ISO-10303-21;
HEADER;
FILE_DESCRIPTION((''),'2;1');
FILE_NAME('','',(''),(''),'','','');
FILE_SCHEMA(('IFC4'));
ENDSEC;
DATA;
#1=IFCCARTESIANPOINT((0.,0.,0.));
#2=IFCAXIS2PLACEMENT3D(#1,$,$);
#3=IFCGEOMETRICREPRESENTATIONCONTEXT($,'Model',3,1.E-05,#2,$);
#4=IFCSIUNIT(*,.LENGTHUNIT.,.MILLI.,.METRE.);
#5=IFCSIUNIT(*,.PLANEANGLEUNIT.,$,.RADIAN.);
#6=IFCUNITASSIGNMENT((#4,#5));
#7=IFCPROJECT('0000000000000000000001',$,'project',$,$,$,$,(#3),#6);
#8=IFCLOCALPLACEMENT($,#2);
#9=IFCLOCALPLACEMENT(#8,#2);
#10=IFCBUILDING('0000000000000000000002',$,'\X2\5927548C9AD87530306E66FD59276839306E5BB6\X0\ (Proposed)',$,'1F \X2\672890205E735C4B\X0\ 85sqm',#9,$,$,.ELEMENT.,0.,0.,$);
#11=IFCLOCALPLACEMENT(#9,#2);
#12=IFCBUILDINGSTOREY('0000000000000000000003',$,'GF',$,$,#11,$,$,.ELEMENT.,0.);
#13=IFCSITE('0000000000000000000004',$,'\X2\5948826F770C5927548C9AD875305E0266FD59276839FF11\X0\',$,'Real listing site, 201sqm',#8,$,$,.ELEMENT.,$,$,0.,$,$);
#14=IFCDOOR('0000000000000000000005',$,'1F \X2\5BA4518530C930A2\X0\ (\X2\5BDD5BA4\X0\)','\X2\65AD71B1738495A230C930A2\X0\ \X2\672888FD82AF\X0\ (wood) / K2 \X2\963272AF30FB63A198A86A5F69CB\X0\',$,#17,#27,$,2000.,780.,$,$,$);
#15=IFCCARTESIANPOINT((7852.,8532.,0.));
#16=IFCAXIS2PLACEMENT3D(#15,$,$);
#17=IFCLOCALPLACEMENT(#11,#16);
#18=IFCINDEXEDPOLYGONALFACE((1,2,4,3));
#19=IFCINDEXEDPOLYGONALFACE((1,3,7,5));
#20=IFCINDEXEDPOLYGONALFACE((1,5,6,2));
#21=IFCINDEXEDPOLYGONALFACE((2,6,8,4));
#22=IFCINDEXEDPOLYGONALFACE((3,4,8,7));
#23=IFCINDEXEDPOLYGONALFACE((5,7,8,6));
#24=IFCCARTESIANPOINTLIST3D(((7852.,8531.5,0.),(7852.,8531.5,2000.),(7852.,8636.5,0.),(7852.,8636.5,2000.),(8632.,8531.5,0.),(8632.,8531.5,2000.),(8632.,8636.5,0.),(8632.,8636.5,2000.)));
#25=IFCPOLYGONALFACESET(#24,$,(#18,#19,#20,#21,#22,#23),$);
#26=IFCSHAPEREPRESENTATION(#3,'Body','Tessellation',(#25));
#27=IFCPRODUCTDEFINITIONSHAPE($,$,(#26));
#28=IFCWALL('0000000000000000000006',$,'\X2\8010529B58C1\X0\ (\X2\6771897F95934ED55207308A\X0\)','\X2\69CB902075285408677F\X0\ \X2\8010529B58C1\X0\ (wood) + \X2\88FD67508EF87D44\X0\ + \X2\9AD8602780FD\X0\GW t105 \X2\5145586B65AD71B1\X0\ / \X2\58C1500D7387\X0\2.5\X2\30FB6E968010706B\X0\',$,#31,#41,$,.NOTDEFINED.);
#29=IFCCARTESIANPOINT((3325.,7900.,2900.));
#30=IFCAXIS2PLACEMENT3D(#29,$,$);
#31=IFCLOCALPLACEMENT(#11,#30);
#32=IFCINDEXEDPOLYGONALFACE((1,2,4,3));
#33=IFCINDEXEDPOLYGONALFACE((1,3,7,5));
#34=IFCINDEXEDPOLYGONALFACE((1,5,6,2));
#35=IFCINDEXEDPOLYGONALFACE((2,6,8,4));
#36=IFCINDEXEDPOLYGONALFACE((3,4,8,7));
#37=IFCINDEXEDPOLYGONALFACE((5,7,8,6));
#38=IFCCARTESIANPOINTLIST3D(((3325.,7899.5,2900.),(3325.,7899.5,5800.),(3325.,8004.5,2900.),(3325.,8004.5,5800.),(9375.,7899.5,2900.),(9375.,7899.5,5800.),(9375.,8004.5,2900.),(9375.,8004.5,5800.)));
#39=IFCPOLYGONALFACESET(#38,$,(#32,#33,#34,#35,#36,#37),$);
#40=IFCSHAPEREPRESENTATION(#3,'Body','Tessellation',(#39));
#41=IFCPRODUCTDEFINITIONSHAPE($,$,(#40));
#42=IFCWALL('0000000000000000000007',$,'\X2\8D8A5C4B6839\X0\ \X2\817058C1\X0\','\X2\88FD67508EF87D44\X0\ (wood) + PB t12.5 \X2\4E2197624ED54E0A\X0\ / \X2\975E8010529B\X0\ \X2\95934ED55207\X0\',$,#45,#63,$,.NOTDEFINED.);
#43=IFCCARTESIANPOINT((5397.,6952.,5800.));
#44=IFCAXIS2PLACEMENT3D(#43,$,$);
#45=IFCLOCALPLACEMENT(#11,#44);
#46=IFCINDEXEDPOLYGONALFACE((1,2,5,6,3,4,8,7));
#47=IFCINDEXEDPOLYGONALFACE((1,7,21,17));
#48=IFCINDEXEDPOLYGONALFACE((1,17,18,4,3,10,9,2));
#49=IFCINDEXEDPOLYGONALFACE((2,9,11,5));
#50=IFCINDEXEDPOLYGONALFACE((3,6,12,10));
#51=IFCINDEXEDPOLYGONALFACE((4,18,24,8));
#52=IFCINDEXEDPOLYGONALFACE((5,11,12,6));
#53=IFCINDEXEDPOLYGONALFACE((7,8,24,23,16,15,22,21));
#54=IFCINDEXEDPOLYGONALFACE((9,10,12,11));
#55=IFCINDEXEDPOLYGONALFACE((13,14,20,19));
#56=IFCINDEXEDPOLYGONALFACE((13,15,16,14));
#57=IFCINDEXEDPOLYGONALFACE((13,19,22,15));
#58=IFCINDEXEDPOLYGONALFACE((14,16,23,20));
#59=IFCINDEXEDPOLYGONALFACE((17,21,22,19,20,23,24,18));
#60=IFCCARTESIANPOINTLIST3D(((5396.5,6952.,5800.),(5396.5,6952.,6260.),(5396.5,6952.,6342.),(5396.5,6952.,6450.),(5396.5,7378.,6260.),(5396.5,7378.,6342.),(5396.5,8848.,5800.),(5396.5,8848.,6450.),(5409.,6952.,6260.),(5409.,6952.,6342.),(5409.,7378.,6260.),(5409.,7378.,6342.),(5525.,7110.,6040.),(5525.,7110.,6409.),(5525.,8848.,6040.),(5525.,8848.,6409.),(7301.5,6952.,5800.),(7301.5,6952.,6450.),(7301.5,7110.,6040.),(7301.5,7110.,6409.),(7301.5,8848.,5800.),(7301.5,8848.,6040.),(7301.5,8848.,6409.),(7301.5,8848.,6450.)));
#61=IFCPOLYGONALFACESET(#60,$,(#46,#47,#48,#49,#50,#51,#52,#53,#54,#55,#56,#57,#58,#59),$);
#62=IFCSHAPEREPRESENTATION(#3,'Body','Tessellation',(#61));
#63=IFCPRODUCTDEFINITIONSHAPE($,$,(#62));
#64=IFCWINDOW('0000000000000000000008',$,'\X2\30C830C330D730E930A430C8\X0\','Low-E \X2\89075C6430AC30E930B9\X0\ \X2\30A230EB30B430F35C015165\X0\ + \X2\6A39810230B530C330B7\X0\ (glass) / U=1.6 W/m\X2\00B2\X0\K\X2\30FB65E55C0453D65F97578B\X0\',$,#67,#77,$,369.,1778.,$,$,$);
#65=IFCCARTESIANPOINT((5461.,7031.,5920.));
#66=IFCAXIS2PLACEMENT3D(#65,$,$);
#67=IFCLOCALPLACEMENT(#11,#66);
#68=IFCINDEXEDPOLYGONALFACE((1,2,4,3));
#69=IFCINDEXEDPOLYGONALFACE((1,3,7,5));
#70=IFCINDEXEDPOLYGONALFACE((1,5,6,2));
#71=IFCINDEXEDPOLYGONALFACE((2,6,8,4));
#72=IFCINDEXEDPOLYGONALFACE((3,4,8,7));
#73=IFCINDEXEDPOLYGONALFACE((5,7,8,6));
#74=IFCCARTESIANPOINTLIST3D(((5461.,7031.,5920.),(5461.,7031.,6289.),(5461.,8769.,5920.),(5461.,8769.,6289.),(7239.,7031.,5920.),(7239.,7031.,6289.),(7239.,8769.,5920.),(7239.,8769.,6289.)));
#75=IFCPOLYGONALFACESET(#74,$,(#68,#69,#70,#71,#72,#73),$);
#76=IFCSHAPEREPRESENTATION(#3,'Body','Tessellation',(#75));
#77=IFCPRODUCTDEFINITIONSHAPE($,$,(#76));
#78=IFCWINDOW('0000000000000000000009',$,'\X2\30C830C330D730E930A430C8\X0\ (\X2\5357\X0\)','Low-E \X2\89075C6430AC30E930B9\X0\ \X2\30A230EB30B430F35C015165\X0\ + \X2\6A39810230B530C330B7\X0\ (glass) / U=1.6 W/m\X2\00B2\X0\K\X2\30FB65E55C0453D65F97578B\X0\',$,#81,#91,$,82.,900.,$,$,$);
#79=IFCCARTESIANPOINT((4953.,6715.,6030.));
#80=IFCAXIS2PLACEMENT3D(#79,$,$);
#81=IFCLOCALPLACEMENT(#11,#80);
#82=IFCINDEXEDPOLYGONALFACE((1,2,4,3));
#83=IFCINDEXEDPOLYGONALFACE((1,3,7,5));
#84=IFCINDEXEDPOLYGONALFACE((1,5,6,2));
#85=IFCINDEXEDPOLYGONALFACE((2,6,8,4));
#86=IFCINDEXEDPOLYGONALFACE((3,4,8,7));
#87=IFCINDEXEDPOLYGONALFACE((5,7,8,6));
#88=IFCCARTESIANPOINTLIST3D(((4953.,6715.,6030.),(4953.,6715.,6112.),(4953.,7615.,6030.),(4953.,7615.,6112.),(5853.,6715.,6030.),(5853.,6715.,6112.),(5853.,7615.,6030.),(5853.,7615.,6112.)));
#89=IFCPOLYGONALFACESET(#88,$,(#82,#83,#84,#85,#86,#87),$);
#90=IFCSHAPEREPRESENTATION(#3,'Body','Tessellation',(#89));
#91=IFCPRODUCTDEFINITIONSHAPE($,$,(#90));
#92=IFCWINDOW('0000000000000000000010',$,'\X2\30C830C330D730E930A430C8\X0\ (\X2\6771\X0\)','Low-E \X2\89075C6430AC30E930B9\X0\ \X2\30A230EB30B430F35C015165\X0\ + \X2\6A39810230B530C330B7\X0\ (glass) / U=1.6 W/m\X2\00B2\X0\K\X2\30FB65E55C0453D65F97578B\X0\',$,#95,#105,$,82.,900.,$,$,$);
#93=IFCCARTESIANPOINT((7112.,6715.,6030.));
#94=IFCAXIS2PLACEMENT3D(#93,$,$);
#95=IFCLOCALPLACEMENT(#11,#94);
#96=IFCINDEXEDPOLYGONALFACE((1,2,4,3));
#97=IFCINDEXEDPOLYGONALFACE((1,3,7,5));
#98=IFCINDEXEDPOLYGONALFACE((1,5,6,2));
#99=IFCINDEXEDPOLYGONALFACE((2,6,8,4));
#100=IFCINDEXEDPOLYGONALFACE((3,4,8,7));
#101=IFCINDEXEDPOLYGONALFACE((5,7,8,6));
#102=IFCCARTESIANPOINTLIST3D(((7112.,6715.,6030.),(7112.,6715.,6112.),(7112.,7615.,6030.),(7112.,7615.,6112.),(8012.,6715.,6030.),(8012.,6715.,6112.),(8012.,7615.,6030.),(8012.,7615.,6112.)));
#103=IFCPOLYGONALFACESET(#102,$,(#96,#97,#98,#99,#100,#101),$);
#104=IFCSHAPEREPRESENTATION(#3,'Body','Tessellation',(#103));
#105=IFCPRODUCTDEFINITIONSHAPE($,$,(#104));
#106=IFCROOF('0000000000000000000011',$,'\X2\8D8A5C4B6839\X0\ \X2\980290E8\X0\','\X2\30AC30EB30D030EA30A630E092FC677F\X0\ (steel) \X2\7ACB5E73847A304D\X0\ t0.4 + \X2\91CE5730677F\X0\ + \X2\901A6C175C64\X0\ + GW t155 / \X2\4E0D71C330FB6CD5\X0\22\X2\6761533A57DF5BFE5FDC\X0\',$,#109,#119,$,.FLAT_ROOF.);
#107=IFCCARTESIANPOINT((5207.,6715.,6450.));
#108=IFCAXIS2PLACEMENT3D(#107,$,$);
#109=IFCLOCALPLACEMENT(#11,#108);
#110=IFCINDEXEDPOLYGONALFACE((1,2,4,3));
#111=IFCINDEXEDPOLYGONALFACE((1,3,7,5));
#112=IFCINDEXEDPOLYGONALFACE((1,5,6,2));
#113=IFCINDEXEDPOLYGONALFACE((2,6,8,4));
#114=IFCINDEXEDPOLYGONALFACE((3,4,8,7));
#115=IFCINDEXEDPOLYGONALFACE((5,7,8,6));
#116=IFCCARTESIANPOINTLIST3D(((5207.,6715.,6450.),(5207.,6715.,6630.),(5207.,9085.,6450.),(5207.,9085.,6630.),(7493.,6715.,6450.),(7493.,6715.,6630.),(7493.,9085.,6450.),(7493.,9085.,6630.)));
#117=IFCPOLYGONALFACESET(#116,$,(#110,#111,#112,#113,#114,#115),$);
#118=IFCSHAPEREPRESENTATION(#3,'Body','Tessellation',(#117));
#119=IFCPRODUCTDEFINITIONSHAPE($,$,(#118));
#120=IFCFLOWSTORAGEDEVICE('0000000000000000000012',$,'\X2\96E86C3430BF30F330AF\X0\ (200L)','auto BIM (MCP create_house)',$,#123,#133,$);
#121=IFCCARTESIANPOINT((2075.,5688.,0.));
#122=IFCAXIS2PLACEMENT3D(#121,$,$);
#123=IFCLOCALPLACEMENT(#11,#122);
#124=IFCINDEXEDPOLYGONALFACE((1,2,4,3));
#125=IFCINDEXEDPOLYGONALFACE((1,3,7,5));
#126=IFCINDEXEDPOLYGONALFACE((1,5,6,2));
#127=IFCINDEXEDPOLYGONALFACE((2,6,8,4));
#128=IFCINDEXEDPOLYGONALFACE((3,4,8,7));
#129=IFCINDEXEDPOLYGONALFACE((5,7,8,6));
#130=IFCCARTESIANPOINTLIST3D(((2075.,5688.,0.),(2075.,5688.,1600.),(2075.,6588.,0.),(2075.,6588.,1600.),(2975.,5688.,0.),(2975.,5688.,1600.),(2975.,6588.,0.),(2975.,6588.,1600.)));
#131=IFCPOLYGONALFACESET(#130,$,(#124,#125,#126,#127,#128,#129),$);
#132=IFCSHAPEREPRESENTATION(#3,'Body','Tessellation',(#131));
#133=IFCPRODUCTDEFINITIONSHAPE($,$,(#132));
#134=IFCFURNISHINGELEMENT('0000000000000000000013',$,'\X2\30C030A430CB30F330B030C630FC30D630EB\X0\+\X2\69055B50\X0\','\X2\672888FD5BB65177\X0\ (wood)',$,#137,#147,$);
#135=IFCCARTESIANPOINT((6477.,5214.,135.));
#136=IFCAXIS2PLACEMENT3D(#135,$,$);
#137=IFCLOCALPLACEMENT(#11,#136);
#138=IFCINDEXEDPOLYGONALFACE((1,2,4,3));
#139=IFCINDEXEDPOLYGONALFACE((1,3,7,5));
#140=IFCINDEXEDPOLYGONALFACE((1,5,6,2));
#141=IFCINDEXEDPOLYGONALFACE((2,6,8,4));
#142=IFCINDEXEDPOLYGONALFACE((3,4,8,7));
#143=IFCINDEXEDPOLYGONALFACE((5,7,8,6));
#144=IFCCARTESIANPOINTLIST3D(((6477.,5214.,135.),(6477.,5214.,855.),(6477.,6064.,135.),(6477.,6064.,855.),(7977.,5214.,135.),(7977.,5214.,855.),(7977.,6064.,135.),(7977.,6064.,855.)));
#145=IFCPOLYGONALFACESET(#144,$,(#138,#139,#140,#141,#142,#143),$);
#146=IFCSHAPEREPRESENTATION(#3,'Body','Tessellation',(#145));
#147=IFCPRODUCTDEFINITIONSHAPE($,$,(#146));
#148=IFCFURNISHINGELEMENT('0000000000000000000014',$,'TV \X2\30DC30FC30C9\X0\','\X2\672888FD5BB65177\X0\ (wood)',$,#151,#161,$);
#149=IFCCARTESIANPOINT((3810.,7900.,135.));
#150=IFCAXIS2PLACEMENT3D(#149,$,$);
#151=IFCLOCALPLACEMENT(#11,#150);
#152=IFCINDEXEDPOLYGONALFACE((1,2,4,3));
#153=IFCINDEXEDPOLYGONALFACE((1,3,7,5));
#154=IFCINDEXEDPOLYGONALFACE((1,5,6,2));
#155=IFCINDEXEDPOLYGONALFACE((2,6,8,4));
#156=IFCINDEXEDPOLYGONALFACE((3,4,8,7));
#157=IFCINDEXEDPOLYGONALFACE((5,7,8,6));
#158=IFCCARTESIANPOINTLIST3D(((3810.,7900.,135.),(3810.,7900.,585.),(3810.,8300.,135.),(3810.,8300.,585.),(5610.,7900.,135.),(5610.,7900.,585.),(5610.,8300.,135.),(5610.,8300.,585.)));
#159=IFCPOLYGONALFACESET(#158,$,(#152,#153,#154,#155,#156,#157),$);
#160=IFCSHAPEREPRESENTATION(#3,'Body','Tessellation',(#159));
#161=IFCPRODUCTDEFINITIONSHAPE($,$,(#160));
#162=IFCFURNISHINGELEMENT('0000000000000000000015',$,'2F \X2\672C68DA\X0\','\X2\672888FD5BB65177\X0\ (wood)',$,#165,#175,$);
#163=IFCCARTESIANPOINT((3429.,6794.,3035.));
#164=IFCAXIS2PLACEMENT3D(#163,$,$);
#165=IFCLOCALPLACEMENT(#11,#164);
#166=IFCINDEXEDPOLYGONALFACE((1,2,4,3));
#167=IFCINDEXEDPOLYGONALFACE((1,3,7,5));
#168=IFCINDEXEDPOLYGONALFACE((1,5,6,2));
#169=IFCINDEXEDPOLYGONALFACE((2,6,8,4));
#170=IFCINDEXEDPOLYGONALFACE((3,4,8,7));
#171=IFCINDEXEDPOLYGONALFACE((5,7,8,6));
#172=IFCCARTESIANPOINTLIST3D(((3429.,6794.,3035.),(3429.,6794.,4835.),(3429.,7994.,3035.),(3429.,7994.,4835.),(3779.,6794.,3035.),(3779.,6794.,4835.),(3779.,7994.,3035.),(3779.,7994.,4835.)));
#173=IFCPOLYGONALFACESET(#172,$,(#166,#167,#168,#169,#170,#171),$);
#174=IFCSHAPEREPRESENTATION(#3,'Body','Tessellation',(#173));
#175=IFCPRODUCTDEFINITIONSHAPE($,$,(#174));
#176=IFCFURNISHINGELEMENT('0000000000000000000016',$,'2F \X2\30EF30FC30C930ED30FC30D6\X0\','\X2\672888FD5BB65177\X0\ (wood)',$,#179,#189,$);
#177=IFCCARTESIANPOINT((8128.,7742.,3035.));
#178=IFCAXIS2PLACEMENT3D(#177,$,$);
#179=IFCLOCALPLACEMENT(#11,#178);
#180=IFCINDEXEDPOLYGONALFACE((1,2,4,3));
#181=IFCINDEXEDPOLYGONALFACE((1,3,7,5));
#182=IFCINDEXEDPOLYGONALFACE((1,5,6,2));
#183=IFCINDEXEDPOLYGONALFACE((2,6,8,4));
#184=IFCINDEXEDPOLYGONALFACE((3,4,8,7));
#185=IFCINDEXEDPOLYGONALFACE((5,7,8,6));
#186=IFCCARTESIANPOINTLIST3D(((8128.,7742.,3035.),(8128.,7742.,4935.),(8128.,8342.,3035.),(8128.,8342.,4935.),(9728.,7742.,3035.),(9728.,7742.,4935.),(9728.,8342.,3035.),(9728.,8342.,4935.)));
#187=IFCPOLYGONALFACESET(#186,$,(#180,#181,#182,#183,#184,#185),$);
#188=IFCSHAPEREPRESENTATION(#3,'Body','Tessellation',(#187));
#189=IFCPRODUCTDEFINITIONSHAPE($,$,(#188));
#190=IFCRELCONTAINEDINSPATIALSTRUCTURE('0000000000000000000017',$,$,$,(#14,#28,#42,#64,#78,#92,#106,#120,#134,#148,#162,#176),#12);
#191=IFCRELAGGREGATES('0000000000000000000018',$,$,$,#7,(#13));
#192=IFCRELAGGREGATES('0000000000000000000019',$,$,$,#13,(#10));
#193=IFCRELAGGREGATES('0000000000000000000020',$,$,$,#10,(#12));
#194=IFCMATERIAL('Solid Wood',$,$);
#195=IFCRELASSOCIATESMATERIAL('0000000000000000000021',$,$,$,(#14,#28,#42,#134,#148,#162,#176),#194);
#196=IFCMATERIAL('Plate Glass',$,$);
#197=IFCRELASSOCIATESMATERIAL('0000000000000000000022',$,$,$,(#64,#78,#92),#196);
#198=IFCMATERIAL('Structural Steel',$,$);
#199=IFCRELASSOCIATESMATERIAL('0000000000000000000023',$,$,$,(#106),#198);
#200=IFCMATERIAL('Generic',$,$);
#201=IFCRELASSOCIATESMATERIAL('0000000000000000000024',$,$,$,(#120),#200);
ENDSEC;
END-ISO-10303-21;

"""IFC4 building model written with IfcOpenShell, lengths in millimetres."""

from ifc_helpers import new_model, si_unit, frame, frame_2d, origin, place, context, project, spatial, rectangle, extrude, material, element, fill, save


model = new_model("IFC4")

# Units and contexts
model_context = context("Model", 3, precision=1e-05, world=origin())
ifc_project = project(units=[si_unit("LENGTHUNIT", "METRE", prefix="MILLI"), si_unit("PLANEANGLEUNIT", "RADIAN")], contexts=[model_context])

# Site, building, storey
site_placement = place(None, origin())
site = spatial("IfcSite", under=ifc_project, at=site_placement, Name="奈良県大和高田市曽大根１", ObjectType="Real listing site, 201sqm", CompositionType="ELEMENT", RefElevation=0.0)
building_placement = place(site_placement, origin())
building = spatial("IfcBuilding", under=site, at=building_placement, Name="大和高田の曽大根の家 (Proposed)", ObjectType="1F 木造平屋 85sqm", CompositionType="ELEMENT", ElevationOfRefHeight=0.0, ElevationOfTerrain=0.0)
storey_placement = place(building_placement, origin())
storey = spatial("IfcBuildingStorey", under=building, at=storey_placement, Name="GF", CompositionType="ELEMENT", Elevation=0.0)

# Shared definitions
ifc_material_1 = material(Name="Solid Wood")

# Door
door_placement = place(storey_placement, frame((7852.0, 8532.0, 0.0)))
element("IfcDoor", 1, at=door_placement, inside=storey, material=ifc_material_1, Name="1F 室内ドア (寝室)", Description="断熱玄関ドア 木製芯 (wood) / K2 防犯・採風機構", OverallHeight=2000.0, OverallWidth=780.0, context=model_context, shape_type="SweptSolid", body=[
    extrude(rectangle(XDim=780.0, YDim=105.0, at=frame_2d((390.0, 52.0))), frame((7852.0, 8532.0, 0.0)), (0.0, 0.0, 1.0), 2000.0),
])

# Wall
wall_1_placement = place(storey_placement, frame((3325.0, 7900.0, 2900.0)))
element("IfcWall", 2, at=wall_1_placement, inside=storey, material=ifc_material_1, Name="耐力壁 (東西間仕切り)", Description="構造用合板 耐力壁 (wood) + 製材軸組 + 高性能GW t105 充填断熱 / 壁倍率2.5・準耐火", PredefinedType="NOTDEFINED", context=model_context, shape_type="SweptSolid", body=[
    extrude(rectangle(XDim=6050.0, YDim=105.0, at=frame_2d((3025.0, 52.0))), frame((3325.0, 7900.0, 2900.0)), (0.0, 0.0, 1.0), 2900.0),
])

# Wall, openings, windows
wall_2_placement = place(storey_placement, frame((5397.0, 6952.0, 5800.0)))
wall_2 = element("IfcWall", 3, at=wall_2_placement, inside=storey, material=ifc_material_1, Name="越屋根 腰壁", Description="製材軸組 (wood) + PB t12.5 両面仕上 / 非耐力 間仕切", PredefinedType="NOTDEFINED", context=model_context, shape_type="SweptSolid", body=[
    extrude(rectangle(XDim=1905.0, YDim=1896.0, at=frame_2d((952.0, 948.0))), frame((5397.0, 6952.0, 5800.0)), (0.0, 0.0, 1.0), 650.0),
])
opening_1_placement = place(storey_placement, frame((5461.0, 7031.0, 5920.0)))
opening_1 = element("IfcOpeningElement", 4, at=opening_1_placement, cuts=wall_2, PredefinedType="NOTDEFINED", context=model_context, shape_type="SweptSolid", body=[
    extrude(rectangle(XDim=1778.0, YDim=1738.0, at=frame_2d((889.0, 869.0))), frame((5461.0, 7031.0, 5920.0)), (0.0, 0.0, 1.0), 369.0),
])
opening_2_placement = place(storey_placement, frame((4953.0, 6715.0, 6030.0)))
opening_2 = element("IfcOpeningElement", 5, at=opening_2_placement, cuts=wall_2, PredefinedType="NOTDEFINED", context=model_context, shape_type="SweptSolid", body=[
    extrude(rectangle(XDim=900.0, YDim=900.0, at=frame_2d((450.0, 450.0))), frame((4953.0, 6715.0, 6030.0)), (0.0, 0.0, 1.0), 82.0),
])
opening_3_placement = place(storey_placement, frame((7112.0, 6715.0, 6030.0)))
opening_3 = element("IfcOpeningElement", 6, at=opening_3_placement, cuts=wall_2, PredefinedType="NOTDEFINED", context=model_context, shape_type="SweptSolid", body=[
    extrude(rectangle(XDim=900.0, YDim=900.0, at=frame_2d((450.0, 450.0))), frame((7112.0, 6715.0, 6030.0)), (0.0, 0.0, 1.0), 82.0),
])
ifc_material_2 = material(Name="Plate Glass")
window_1_placement = place(storey_placement, frame((5461.0, 7031.0, 5920.0)))
window_1 = element("IfcWindow", 7, at=window_1_placement, inside=storey, material=ifc_material_2, Name="トップライト", Description="Low-E 複層ガラス アルゴン封入 + 樹脂サッシ (glass) / U=1.6 W/m²K・日射取得型", OverallHeight=369.0, OverallWidth=1778.0, context=model_context, shape_type="SweptSolid", body=[
    extrude(rectangle(XDim=1778.0, YDim=1738.0, at=frame_2d((889.0, 869.0))), frame((5461.0, 7031.0, 5920.0)), (0.0, 0.0, 1.0), 369.0),
])
fill(opening_1, window_1)
window_2_placement = place(storey_placement, frame((4953.0, 6715.0, 6030.0)))
window_2 = element("IfcWindow", 8, at=window_2_placement, inside=storey, material=ifc_material_2, Name="トップライト (南)", Description="Low-E 複層ガラス アルゴン封入 + 樹脂サッシ (glass) / U=1.6 W/m²K・日射取得型", OverallHeight=82.0, OverallWidth=900.0, context=model_context, shape_type="SweptSolid", body=[
    extrude(rectangle(XDim=900.0, YDim=900.0, at=frame_2d((450.0, 450.0))), frame((4953.0, 6715.0, 6030.0)), (0.0, 0.0, 1.0), 82.0),
])
fill(opening_2, window_2)
window_3_placement = place(storey_placement, frame((7112.0, 6715.0, 6030.0)))
window_3 = element("IfcWindow", 9, at=window_3_placement, inside=storey, material=ifc_material_2, Name="トップライト (東)", Description="Low-E 複層ガラス アルゴン封入 + 樹脂サッシ (glass) / U=1.6 W/m²K・日射取得型", OverallHeight=82.0, OverallWidth=900.0, context=model_context, shape_type="SweptSolid", body=[
    extrude(rectangle(XDim=900.0, YDim=900.0, at=frame_2d((450.0, 450.0))), frame((7112.0, 6715.0, 6030.0)), (0.0, 0.0, 1.0), 82.0),
])
fill(opening_3, window_3)

# Roof
ifc_material_3 = material(Name="Structural Steel")
roof_placement = place(storey_placement, frame((5207.0, 6715.0, 6450.0)))
element("IfcRoof", 10, at=roof_placement, inside=storey, material=ifc_material_3, Name="越屋根 頂部", Description="ガルバリウム鋼板 (steel) 立平葺き t0.4 + 野地板 + 通気層 + GW t155 / 不燃・法22条区域対応", PredefinedType="FLAT_ROOF", context=model_context, shape_type="SweptSolid", body=[
    extrude(rectangle(XDim=2286.0, YDim=2370.0, at=frame_2d((1143.0, 1185.0))), frame((5207.0, 6715.0, 6450.0)), (0.0, 0.0, 1.0), 180.0),
])

# Flow storage device
ifc_material_4 = material(Name="Generic")
flow_storage_device_placement = place(storey_placement, frame((2075.0, 5688.0, 0.0)))
element("IfcFlowStorageDevice", 11, at=flow_storage_device_placement, inside=storey, material=ifc_material_4, Name="雨水タンク (200L)", Description="auto BIM (MCP create_house)", context=model_context, shape_type="SweptSolid", body=[
    extrude(rectangle(XDim=900.0, YDim=900.0, at=frame_2d((450.0, 450.0))), frame((2075.0, 5688.0, 0.0)), (0.0, 0.0, 1.0), 1600.0),
])

# Furnishing elements
furnishing_1_placement = place(storey_placement, frame((6477.0, 5214.0, 135.0)))
element("IfcFurnishingElement", 12, at=furnishing_1_placement, inside=storey, material=ifc_material_1, Name="ダイニングテーブル+椅子", Description="木製家具 (wood)", context=model_context, shape_type="SweptSolid", body=[
    extrude(rectangle(XDim=1500.0, YDim=850.0, at=frame_2d((750.0, 425.0))), frame((6477.0, 5214.0, 135.0)), (0.0, 0.0, 1.0), 720.0),
])
furnishing_2_placement = place(storey_placement, frame((3810.0, 7900.0, 135.0)))
element("IfcFurnishingElement", 13, at=furnishing_2_placement, inside=storey, material=ifc_material_1, Name="TV ボード", Description="木製家具 (wood)", context=model_context, shape_type="SweptSolid", body=[
    extrude(rectangle(XDim=1800.0, YDim=400.0, at=frame_2d((900.0, 200.0))), frame((3810.0, 7900.0, 135.0)), (0.0, 0.0, 1.0), 450.0),
])
furnishing_3_placement = place(storey_placement, frame((3429.0, 6794.0, 3035.0)))
element("IfcFurnishingElement", 14, at=furnishing_3_placement, inside=storey, material=ifc_material_1, Name="2F 本棚", Description="木製家具 (wood)", context=model_context, shape_type="SweptSolid", body=[
    extrude(rectangle(XDim=350.0, YDim=1200.0, at=frame_2d((175.0, 600.0))), frame((3429.0, 6794.0, 3035.0)), (0.0, 0.0, 1.0), 1800.0),
])
furnishing_4_placement = place(storey_placement, frame((8128.0, 7742.0, 3035.0)))
element("IfcFurnishingElement", 15, at=furnishing_4_placement, inside=storey, material=ifc_material_1, Name="2F ワードローブ", Description="木製家具 (wood)", context=model_context, shape_type="SweptSolid", body=[
    extrude(rectangle(XDim=1600.0, YDim=600.0, at=frame_2d((800.0, 300.0))), frame((8128.0, 7742.0, 3035.0)), (0.0, 0.0, 1.0), 1900.0),
])

save(model, "model.ifc")
